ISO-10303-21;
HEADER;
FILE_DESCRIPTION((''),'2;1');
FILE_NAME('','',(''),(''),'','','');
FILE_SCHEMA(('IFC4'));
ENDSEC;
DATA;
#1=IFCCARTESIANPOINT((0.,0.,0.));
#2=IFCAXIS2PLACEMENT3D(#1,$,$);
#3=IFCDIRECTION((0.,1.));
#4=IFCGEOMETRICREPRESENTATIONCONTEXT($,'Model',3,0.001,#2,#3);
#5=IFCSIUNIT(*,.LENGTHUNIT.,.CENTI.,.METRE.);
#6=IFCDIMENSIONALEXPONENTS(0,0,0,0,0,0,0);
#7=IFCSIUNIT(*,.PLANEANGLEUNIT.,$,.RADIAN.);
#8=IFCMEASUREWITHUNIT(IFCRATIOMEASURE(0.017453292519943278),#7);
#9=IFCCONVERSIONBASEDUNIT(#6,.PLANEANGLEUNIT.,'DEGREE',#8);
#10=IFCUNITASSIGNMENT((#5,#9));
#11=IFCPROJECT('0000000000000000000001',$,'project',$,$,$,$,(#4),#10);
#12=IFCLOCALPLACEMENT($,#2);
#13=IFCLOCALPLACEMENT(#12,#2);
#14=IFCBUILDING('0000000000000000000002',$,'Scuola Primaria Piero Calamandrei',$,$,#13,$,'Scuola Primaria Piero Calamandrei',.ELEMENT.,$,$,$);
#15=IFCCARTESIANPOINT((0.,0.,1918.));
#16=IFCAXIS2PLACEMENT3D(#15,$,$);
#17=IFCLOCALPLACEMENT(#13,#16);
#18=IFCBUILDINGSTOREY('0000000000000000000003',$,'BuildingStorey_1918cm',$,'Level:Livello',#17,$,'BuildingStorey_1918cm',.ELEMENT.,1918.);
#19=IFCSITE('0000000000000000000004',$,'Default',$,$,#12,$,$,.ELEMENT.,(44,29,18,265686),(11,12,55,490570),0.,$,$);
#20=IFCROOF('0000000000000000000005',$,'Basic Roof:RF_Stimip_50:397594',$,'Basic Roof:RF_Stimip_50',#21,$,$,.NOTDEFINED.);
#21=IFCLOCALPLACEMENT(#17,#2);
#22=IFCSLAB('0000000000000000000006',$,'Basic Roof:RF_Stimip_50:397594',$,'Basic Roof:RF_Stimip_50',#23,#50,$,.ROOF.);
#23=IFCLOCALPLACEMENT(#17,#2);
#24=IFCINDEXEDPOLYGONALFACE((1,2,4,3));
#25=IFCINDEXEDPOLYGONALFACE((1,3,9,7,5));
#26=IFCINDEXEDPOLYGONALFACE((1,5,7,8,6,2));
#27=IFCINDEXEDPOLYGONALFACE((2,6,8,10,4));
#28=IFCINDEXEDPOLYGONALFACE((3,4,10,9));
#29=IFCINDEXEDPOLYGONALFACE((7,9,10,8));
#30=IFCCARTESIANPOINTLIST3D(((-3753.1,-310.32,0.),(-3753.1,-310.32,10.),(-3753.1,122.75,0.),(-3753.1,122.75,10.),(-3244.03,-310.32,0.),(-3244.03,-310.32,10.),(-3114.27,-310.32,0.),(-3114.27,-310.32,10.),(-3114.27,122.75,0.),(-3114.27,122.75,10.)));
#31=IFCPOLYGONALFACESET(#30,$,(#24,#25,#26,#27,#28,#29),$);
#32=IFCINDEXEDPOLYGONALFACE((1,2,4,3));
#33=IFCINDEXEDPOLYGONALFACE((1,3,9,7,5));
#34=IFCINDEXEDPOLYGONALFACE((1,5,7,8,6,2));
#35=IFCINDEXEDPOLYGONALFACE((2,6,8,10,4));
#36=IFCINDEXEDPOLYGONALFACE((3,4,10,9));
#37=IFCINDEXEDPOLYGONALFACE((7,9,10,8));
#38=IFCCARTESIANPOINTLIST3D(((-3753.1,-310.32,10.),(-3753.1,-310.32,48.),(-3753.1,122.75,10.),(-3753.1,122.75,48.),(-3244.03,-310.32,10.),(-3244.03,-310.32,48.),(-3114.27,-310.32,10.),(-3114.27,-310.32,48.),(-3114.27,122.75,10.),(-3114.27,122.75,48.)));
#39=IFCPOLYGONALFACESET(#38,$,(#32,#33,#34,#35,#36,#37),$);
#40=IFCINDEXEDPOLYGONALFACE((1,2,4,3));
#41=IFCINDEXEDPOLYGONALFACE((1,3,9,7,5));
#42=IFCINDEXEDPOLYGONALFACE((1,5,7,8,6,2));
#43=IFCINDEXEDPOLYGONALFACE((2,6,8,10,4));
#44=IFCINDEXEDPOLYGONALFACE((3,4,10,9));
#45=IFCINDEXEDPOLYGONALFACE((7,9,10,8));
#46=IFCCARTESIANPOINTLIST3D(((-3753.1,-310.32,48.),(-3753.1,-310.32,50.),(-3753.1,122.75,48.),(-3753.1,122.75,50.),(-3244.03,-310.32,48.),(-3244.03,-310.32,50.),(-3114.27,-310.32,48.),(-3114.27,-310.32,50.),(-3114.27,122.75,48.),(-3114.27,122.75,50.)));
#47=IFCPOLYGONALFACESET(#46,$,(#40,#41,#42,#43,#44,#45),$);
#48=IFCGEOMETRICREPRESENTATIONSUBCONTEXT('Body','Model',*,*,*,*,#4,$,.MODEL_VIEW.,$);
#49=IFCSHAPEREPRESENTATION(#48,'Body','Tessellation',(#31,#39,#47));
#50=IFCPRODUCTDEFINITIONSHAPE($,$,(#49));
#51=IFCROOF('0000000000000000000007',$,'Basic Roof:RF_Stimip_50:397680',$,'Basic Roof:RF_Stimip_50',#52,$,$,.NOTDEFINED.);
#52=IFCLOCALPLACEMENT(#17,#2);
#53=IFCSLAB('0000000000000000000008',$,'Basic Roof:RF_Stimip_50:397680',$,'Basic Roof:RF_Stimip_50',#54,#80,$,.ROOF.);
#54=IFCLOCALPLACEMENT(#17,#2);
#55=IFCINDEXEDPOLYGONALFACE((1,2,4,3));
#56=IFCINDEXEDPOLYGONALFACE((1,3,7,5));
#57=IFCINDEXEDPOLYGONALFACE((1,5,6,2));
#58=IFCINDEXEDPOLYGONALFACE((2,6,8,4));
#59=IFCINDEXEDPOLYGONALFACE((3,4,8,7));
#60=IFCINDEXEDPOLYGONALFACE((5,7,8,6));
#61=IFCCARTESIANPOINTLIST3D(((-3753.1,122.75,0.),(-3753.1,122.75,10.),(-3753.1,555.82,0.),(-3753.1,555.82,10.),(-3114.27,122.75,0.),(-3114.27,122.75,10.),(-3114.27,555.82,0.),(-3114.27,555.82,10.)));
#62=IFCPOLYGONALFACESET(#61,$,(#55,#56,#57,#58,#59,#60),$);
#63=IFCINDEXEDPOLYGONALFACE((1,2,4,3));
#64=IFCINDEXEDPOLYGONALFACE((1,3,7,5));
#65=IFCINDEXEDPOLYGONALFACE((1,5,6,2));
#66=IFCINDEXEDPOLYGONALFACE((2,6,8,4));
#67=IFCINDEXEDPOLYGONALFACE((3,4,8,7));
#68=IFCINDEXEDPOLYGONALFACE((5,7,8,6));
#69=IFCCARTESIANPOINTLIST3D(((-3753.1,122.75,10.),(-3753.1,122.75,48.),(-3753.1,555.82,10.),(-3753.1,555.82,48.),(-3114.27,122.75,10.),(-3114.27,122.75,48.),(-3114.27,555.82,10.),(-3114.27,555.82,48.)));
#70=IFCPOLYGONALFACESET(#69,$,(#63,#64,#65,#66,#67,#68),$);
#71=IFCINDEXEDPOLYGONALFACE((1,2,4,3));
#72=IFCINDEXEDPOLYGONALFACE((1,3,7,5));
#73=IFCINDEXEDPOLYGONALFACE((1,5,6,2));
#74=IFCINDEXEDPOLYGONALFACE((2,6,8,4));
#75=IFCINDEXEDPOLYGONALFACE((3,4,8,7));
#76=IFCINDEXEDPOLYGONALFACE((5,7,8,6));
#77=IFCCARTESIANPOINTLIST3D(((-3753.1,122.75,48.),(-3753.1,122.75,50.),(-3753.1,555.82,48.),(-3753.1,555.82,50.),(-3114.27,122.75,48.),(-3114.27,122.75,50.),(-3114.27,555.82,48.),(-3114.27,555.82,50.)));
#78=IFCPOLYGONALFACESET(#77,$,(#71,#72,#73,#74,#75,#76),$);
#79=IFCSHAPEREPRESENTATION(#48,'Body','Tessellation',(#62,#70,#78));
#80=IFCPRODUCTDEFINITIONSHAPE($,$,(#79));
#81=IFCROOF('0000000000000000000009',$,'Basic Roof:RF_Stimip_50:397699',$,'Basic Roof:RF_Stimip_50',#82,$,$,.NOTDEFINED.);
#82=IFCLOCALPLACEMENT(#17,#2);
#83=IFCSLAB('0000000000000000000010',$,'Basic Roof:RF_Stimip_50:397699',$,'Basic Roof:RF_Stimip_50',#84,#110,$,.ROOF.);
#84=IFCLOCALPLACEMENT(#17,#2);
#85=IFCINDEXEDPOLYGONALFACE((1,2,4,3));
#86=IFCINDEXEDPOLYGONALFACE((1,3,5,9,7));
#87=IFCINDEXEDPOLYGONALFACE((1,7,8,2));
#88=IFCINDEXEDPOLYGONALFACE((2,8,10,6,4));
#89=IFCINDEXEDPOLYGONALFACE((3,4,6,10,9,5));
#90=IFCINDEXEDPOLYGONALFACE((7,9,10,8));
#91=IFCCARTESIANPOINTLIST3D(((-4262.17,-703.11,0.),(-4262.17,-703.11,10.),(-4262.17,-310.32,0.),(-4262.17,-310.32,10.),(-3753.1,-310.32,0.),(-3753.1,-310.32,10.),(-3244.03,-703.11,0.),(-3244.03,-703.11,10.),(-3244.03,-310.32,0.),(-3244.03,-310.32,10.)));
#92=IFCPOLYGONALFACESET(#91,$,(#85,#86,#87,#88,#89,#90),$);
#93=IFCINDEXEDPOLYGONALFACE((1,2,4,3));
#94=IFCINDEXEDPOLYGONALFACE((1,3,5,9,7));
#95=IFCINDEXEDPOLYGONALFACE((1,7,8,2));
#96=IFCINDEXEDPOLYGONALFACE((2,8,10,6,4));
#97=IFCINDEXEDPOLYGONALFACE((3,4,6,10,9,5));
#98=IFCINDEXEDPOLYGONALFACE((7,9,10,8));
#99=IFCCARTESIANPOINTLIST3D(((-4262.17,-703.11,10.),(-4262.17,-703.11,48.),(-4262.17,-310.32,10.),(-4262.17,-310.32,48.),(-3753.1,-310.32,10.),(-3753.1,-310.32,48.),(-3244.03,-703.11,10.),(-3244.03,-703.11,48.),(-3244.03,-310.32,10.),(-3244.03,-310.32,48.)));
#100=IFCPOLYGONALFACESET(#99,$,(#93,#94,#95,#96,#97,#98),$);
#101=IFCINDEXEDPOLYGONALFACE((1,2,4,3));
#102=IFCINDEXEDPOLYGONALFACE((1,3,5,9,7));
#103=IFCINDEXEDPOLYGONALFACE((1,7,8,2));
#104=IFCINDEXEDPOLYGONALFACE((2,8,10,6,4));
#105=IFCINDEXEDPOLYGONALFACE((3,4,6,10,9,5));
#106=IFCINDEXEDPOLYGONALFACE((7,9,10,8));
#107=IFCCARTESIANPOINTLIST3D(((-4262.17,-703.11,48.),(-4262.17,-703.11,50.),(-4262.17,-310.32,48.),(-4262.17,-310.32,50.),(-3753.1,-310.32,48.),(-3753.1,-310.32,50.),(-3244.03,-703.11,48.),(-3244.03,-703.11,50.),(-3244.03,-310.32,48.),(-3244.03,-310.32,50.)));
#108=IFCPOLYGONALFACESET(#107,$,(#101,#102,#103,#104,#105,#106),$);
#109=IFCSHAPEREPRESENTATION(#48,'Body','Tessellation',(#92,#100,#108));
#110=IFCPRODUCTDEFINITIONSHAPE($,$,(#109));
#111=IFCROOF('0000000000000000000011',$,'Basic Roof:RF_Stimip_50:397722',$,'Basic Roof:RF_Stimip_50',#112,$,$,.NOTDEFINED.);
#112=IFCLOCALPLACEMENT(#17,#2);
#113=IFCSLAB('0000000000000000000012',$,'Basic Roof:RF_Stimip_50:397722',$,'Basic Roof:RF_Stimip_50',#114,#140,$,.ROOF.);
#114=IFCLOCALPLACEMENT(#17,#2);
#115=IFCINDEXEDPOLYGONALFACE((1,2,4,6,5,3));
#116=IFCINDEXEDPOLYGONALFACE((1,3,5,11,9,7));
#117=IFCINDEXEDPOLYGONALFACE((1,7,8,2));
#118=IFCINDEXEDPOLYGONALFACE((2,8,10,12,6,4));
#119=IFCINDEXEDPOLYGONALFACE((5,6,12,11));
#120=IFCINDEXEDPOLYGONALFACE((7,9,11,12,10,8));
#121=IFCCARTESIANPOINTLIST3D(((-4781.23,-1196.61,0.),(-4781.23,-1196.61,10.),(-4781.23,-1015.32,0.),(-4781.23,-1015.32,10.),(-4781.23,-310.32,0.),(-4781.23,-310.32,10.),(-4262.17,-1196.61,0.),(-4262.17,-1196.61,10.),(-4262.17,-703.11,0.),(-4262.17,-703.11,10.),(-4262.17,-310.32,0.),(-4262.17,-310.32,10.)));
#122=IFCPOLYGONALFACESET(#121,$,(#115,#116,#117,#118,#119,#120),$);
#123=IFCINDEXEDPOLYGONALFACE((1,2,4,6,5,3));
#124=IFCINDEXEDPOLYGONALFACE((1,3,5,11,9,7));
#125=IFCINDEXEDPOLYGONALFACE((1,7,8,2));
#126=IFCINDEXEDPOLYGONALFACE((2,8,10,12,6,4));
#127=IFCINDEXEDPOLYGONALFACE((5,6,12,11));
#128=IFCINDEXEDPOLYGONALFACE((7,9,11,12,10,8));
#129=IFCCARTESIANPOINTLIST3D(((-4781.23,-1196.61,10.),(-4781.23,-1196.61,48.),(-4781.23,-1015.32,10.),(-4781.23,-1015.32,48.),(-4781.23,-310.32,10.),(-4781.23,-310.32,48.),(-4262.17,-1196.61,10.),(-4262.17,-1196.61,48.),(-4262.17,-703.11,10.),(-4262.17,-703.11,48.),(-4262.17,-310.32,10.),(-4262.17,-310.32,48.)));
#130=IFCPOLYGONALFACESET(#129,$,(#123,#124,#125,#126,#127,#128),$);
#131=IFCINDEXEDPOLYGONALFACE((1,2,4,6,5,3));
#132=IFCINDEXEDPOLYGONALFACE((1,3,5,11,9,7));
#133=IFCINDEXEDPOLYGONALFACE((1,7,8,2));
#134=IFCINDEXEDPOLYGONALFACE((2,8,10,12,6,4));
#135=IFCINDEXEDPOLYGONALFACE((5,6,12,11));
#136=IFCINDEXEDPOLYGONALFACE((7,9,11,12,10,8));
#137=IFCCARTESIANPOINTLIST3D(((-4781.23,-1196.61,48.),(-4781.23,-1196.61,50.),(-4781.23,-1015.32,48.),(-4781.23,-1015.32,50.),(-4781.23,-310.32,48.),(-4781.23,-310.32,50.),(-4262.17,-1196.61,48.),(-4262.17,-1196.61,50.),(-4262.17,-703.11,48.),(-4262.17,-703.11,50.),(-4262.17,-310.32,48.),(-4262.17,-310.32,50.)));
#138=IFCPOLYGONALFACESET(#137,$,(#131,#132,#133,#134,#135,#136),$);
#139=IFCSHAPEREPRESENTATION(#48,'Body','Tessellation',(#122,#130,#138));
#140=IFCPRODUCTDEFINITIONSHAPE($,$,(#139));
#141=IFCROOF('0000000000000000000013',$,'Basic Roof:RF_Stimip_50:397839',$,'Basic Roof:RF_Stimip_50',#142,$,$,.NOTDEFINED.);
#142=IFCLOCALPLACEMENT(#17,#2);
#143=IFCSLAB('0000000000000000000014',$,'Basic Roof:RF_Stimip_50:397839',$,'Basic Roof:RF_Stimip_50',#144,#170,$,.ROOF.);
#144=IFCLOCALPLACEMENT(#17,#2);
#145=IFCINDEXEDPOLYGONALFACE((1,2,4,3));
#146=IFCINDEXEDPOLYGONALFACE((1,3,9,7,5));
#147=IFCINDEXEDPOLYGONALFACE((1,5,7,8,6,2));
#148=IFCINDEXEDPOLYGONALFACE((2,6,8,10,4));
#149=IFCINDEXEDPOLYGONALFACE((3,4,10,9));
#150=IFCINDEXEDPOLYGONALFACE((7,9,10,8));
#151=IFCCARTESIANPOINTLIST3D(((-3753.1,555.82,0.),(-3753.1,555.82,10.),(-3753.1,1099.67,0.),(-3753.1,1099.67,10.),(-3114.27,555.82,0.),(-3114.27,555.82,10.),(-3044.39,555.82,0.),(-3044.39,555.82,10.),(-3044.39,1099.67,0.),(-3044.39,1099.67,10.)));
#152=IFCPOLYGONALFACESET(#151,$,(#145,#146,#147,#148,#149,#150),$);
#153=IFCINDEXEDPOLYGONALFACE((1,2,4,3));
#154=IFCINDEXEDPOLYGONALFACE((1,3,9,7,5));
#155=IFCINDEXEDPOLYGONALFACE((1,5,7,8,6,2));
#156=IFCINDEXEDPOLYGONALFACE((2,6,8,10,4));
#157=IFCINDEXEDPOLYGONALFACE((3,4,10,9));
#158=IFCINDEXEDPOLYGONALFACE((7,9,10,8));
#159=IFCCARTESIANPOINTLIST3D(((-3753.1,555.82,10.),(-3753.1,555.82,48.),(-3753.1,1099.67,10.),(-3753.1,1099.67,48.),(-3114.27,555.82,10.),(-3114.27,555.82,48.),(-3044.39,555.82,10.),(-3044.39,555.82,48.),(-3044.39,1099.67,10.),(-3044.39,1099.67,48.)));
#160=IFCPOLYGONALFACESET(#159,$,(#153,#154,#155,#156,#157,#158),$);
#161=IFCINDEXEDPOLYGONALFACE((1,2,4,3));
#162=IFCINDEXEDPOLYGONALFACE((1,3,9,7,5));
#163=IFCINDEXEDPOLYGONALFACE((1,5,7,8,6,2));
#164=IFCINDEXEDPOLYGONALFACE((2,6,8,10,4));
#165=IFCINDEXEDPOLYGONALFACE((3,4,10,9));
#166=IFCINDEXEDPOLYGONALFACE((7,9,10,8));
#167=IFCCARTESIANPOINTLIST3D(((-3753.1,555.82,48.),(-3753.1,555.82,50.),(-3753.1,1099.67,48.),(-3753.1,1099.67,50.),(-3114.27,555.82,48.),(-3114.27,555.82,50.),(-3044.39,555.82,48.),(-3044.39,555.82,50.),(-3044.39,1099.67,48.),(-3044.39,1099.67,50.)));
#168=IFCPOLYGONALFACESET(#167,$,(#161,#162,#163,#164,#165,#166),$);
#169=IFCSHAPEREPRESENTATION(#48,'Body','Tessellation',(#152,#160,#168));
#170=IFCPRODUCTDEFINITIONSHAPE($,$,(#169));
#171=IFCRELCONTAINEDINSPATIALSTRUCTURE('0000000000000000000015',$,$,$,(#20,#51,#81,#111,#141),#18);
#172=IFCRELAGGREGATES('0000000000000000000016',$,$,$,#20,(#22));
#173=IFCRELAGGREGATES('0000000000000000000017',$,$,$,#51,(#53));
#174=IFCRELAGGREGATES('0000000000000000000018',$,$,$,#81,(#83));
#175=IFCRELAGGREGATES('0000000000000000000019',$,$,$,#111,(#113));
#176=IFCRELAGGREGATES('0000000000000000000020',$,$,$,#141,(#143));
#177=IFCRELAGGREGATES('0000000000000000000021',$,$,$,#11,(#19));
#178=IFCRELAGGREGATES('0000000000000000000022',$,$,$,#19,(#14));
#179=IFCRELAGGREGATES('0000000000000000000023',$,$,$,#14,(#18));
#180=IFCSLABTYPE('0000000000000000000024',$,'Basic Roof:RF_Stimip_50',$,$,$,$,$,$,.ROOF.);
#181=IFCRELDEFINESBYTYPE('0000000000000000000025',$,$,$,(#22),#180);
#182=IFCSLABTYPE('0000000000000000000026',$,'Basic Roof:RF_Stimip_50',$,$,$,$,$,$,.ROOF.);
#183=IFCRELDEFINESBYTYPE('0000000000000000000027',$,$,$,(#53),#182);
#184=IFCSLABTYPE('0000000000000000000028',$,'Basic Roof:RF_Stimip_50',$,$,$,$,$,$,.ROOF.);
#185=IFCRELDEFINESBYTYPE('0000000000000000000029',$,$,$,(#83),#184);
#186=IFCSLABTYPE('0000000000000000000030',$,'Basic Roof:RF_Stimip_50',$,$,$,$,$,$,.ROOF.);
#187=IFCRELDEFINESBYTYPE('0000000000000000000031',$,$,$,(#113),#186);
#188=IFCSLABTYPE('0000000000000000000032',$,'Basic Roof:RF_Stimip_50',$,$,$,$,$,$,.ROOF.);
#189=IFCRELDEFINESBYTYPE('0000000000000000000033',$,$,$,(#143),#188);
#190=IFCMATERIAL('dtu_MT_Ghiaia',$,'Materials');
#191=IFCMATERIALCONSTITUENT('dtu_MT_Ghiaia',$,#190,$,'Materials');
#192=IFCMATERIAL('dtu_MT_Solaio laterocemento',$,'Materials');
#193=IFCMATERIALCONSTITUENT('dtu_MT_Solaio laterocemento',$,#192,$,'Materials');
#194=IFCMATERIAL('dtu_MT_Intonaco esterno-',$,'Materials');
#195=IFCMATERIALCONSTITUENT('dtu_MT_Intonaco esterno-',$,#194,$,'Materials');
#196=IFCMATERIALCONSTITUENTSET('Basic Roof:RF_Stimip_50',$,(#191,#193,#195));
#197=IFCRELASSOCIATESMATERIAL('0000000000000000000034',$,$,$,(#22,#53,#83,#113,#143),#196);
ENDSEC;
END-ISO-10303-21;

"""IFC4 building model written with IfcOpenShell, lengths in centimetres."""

from ifc_helpers import new_model, entity, si_unit, converted_unit, direction, frame, origin, place, context, subcontext, project, spatial, indexed_curve, outline, extrude, material, constituent, constituent_set, type_object, element, aggregate, save


model = new_model("IFC4")

# Units and contexts
model_context = context("Model", 3, precision=0.001, world=origin(), true_north=direction((0.0, 1.0)))
body_context = subcontext(model_context, "Body", "Model", "MODEL_VIEW")
ifc_project = project(units=[si_unit("LENGTHUNIT", "METRE", prefix="CENTI"), converted_unit("PLANEANGLEUNIT", "DEGREE", entity("IfcRatioMeasure", 0.017453292519943278), si_unit("PLANEANGLEUNIT", "RADIAN"), dimensions=[0, 0, 0, 0, 0, 0, 0])], contexts=[model_context])

# Site, building, storey
site_placement = place(None, origin())
site = spatial("IfcSite", under=ifc_project, at=site_placement, Name="Default", CompositionType="ELEMENT", RefLatitude=(44, 29, 18, 265686), RefLongitude=(11, 12, 55, 490570), RefElevation=0.0)
building_placement = place(site_placement, origin())
building = spatial("IfcBuilding", under=site, at=building_placement, Name="Scuola Primaria Piero Calamandrei", LongName="Scuola Primaria Piero Calamandrei", CompositionType="ELEMENT")
storey_placement = place(building_placement, frame((0.0, 0.0, 1918.0)))
storey = spatial("IfcBuildingStorey", under=building, at=storey_placement, Name="BuildingStorey_1918cm", ObjectType="Level:Livello", LongName="BuildingStorey_1918cm", CompositionType="ELEMENT", Elevation=1918.0)

# Roofs, slabs
roof_1_placement = place(storey_placement, frame((-3753.1, -310.32, 0.0)))
roof_1 = element("IfcRoof", 1, at=roof_1_placement, inside=storey, Name="Basic Roof:RF_Stimip_50:397594", ObjectType="Basic Roof:RF_Stimip_50", PredefinedType="NOTDEFINED")
ifc_material_1 = material(Name="dtu_MT_Ghiaia", Category="Materials")
ifc_constituent_1 = constituent(ifc_material_1, Name="dtu_MT_Ghiaia", Category="Materials")
ifc_material_2 = material(Name="dtu_MT_Solaio laterocemento", Category="Materials")
ifc_constituent_2 = constituent(ifc_material_2, Name="dtu_MT_Solaio laterocemento", Category="Materials")
ifc_material_3 = material(Name="dtu_MT_Intonaco esterno-", Category="Materials")
ifc_constituent_3 = constituent(ifc_material_3, Name="dtu_MT_Intonaco esterno-", Category="Materials")
ifc_constituent_set = constituent_set(constituents=[ifc_constituent_1, ifc_constituent_2, ifc_constituent_3], Name="Basic Roof:RF_Stimip_50")
slab_type_1 = type_object("IfcSlabType", Name="Basic Roof:RF_Stimip_50", PredefinedType="ROOF")
slab_1_placement = place(roof_1_placement, origin())
slab_1 = element("IfcSlab", 2, at=slab_1_placement, type_object=slab_type_1, material=ifc_constituent_set, Name="Basic Roof:RF_Stimip_50:397594", ObjectType="Basic Roof:RF_Stimip_50", PredefinedType="ROOF", context=body_context, shape_type="SweptSolid", body=[
    extrude(outline(indexed_curve([(319.42, -216.54), (319.42, 216.54), (-319.42, 216.54), (-319.42, -216.54), (189.65, -216.54), (319.42, -216.54)], self_intersect=False)), frame((319.42, 216.54, 0.0)), (0.0, 0.0, 1.0), 10.0),
    extrude(outline(indexed_curve([(319.42, -216.54), (319.42, 216.54), (-319.42, 216.54), (-319.42, -216.54), (189.65, -216.54), (319.42, -216.54)], self_intersect=False)), frame((319.42, 216.54, 10.0)), (0.0, 0.0, 1.0), 38.0),
    extrude(outline(indexed_curve([(319.42, -216.54), (319.42, 216.54), (-319.42, 216.54), (-319.42, -216.54), (189.65, -216.54), (319.42, -216.54)], self_intersect=False)), frame((319.42, 216.54, 48.0)), (0.0, 0.0, 1.0), 2.0),
])
aggregate(roof_1, [slab_1])
roof_2_placement = place(storey_placement, frame((-3753.1, 122.75, 0.0)))
roof_2 = element("IfcRoof", 3, at=roof_2_placement, inside=storey, Name="Basic Roof:RF_Stimip_50:397680", ObjectType="Basic Roof:RF_Stimip_50", PredefinedType="NOTDEFINED")
slab_type_2 = type_object("IfcSlabType", Name="Basic Roof:RF_Stimip_50", PredefinedType="ROOF")
slab_2_placement = place(roof_2_placement, origin())
slab_2 = element("IfcSlab", 4, at=slab_2_placement, type_object=slab_type_2, material=ifc_constituent_set, Name="Basic Roof:RF_Stimip_50:397680", ObjectType="Basic Roof:RF_Stimip_50", PredefinedType="ROOF", context=body_context, shape_type="SweptSolid", body=[
    extrude(outline(indexed_curve([(-319.42, -216.54), (319.42, -216.54), (319.42, 216.54), (-319.42, 216.54), (-319.42, -216.54)], self_intersect=False)), frame((319.42, 216.54, 0.0)), (0.0, 0.0, 1.0), 10.0),
    extrude(outline(indexed_curve([(-319.42, -216.54), (319.42, -216.54), (319.42, 216.54), (-319.42, 216.54), (-319.42, -216.54)], self_intersect=False)), frame((319.42, 216.54, 10.0)), (0.0, 0.0, 1.0), 38.0),
    extrude(outline(indexed_curve([(-319.42, -216.54), (319.42, -216.54), (319.42, 216.54), (-319.42, 216.54), (-319.42, -216.54)], self_intersect=False)), frame((319.42, 216.54, 48.0)), (0.0, 0.0, 1.0), 2.0),
])
aggregate(roof_2, [slab_2])
roof_3_placement = place(storey_placement, frame((-4262.17, -703.11, 0.0)))
roof_3 = element("IfcRoof", 5, at=roof_3_placement, inside=storey, Name="Basic Roof:RF_Stimip_50:397699", ObjectType="Basic Roof:RF_Stimip_50", PredefinedType="NOTDEFINED")
slab_type_3 = type_object("IfcSlabType", Name="Basic Roof:RF_Stimip_50", PredefinedType="ROOF")
slab_3_placement = place(roof_3_placement, origin())
slab_3 = element("IfcSlab", 6, at=slab_3_placement, type_object=slab_type_3, material=ifc_constituent_set, Name="Basic Roof:RF_Stimip_50:397699", ObjectType="Basic Roof:RF_Stimip_50", PredefinedType="ROOF", context=body_context, shape_type="SweptSolid", body=[
    extrude(outline(indexed_curve([(-509.07, 196.39), (-509.07, -196.39), (509.07, -196.39), (509.07, 196.39), (0.0, 196.39), (-509.07, 196.39)], self_intersect=False)), frame((509.07, 196.39, 0.0)), (0.0, 0.0, 1.0), 10.0),
    extrude(outline(indexed_curve([(-509.07, 196.39), (-509.07, -196.39), (509.07, -196.39), (509.07, 196.39), (0.0, 196.39), (-509.07, 196.39)], self_intersect=False)), frame((509.07, 196.39, 10.0)), (0.0, 0.0, 1.0), 38.0),
    extrude(outline(indexed_curve([(-509.07, 196.39), (-509.07, -196.39), (509.07, -196.39), (509.07, 196.39), (0.0, 196.39), (-509.07, 196.39)], self_intersect=False)), frame((509.07, 196.39, 48.0)), (0.0, 0.0, 1.0), 2.0),
])
aggregate(roof_3, [slab_3])
roof_4_placement = place(storey_placement, frame((-4781.23, -1196.61, 0.0)))
roof_4 = element("IfcRoof", 7, at=roof_4_placement, inside=storey, Name="Basic Roof:RF_Stimip_50:397722", ObjectType="Basic Roof:RF_Stimip_50", PredefinedType="NOTDEFINED")
slab_type_4 = type_object("IfcSlabType", Name="Basic Roof:RF_Stimip_50", PredefinedType="ROOF")
slab_4_placement = place(roof_4_placement, origin())
slab_4 = element("IfcSlab", 8, at=slab_4_placement, type_object=slab_type_4, material=ifc_constituent_set, Name="Basic Roof:RF_Stimip_50:397722", ObjectType="Basic Roof:RF_Stimip_50", PredefinedType="ROOF", context=body_context, shape_type="SweptSolid", body=[
    extrude(outline(indexed_curve([(-259.53, 443.14), (-259.53, -261.86), (-259.53, -443.14), (259.53, -443.14), (259.53, 50.36), (259.53, 443.14), (-259.53, 443.14)], self_intersect=False)), frame((259.53, 443.14, 0.0)), (0.0, 0.0, 1.0), 10.0),
    extrude(outline(indexed_curve([(-259.53, 443.14), (-259.53, -261.86), (-259.53, -443.14), (259.53, -443.14), (259.53, 50.36), (259.53, 443.14), (-259.53, 443.14)], self_intersect=False)), frame((259.53, 443.14, 10.0)), (0.0, 0.0, 1.0), 38.0),
    extrude(outline(indexed_curve([(-259.53, 443.14), (-259.53, -261.86), (-259.53, -443.14), (259.53, -443.14), (259.53, 50.36), (259.53, 443.14), (-259.53, 443.14)], self_intersect=False)), frame((259.53, 443.14, 48.0)), (0.0, 0.0, 1.0), 2.0),
])
aggregate(roof_4, [slab_4])
roof_5_placement = place(storey_placement, frame((-3753.1, 555.82, 0.0)))
roof_5 = element("IfcRoof", 9, at=roof_5_placement, inside=storey, Name="Basic Roof:RF_Stimip_50:397839", ObjectType="Basic Roof:RF_Stimip_50", PredefinedType="NOTDEFINED")
slab_type_5 = type_object("IfcSlabType", Name="Basic Roof:RF_Stimip_50", PredefinedType="ROOF")
slab_5_placement = place(roof_5_placement, origin())
slab_5 = element("IfcSlab", 10, at=slab_5_placement, type_object=slab_type_5, material=ifc_constituent_set, Name="Basic Roof:RF_Stimip_50:397839", ObjectType="Basic Roof:RF_Stimip_50", PredefinedType="ROOF", context=body_context, shape_type="SweptSolid", body=[
    extrude(outline(indexed_curve([(-354.35, 271.93), (-354.35, -271.93), (284.48, -271.93), (354.35, -271.93), (354.35, 271.93), (-354.35, 271.93)], self_intersect=False)), frame((354.35, 271.93, 0.0)), (0.0, 0.0, 1.0), 10.0),
    extrude(outline(indexed_curve([(-354.35, 271.93), (-354.35, -271.93), (284.48, -271.93), (354.35, -271.93), (354.35, 271.93), (-354.35, 271.93)], self_intersect=False)), frame((354.35, 271.93, 10.0)), (0.0, 0.0, 1.0), 38.0),
    extrude(outline(indexed_curve([(-354.35, 271.93), (-354.35, -271.93), (284.48, -271.93), (354.35, -271.93), (354.35, 271.93), (-354.35, 271.93)], self_intersect=False)), frame((354.35, 271.93, 48.0)), (0.0, 0.0, 1.0), 2.0),
])
aggregate(roof_5, [slab_5])

save(model, "model.ifc")
